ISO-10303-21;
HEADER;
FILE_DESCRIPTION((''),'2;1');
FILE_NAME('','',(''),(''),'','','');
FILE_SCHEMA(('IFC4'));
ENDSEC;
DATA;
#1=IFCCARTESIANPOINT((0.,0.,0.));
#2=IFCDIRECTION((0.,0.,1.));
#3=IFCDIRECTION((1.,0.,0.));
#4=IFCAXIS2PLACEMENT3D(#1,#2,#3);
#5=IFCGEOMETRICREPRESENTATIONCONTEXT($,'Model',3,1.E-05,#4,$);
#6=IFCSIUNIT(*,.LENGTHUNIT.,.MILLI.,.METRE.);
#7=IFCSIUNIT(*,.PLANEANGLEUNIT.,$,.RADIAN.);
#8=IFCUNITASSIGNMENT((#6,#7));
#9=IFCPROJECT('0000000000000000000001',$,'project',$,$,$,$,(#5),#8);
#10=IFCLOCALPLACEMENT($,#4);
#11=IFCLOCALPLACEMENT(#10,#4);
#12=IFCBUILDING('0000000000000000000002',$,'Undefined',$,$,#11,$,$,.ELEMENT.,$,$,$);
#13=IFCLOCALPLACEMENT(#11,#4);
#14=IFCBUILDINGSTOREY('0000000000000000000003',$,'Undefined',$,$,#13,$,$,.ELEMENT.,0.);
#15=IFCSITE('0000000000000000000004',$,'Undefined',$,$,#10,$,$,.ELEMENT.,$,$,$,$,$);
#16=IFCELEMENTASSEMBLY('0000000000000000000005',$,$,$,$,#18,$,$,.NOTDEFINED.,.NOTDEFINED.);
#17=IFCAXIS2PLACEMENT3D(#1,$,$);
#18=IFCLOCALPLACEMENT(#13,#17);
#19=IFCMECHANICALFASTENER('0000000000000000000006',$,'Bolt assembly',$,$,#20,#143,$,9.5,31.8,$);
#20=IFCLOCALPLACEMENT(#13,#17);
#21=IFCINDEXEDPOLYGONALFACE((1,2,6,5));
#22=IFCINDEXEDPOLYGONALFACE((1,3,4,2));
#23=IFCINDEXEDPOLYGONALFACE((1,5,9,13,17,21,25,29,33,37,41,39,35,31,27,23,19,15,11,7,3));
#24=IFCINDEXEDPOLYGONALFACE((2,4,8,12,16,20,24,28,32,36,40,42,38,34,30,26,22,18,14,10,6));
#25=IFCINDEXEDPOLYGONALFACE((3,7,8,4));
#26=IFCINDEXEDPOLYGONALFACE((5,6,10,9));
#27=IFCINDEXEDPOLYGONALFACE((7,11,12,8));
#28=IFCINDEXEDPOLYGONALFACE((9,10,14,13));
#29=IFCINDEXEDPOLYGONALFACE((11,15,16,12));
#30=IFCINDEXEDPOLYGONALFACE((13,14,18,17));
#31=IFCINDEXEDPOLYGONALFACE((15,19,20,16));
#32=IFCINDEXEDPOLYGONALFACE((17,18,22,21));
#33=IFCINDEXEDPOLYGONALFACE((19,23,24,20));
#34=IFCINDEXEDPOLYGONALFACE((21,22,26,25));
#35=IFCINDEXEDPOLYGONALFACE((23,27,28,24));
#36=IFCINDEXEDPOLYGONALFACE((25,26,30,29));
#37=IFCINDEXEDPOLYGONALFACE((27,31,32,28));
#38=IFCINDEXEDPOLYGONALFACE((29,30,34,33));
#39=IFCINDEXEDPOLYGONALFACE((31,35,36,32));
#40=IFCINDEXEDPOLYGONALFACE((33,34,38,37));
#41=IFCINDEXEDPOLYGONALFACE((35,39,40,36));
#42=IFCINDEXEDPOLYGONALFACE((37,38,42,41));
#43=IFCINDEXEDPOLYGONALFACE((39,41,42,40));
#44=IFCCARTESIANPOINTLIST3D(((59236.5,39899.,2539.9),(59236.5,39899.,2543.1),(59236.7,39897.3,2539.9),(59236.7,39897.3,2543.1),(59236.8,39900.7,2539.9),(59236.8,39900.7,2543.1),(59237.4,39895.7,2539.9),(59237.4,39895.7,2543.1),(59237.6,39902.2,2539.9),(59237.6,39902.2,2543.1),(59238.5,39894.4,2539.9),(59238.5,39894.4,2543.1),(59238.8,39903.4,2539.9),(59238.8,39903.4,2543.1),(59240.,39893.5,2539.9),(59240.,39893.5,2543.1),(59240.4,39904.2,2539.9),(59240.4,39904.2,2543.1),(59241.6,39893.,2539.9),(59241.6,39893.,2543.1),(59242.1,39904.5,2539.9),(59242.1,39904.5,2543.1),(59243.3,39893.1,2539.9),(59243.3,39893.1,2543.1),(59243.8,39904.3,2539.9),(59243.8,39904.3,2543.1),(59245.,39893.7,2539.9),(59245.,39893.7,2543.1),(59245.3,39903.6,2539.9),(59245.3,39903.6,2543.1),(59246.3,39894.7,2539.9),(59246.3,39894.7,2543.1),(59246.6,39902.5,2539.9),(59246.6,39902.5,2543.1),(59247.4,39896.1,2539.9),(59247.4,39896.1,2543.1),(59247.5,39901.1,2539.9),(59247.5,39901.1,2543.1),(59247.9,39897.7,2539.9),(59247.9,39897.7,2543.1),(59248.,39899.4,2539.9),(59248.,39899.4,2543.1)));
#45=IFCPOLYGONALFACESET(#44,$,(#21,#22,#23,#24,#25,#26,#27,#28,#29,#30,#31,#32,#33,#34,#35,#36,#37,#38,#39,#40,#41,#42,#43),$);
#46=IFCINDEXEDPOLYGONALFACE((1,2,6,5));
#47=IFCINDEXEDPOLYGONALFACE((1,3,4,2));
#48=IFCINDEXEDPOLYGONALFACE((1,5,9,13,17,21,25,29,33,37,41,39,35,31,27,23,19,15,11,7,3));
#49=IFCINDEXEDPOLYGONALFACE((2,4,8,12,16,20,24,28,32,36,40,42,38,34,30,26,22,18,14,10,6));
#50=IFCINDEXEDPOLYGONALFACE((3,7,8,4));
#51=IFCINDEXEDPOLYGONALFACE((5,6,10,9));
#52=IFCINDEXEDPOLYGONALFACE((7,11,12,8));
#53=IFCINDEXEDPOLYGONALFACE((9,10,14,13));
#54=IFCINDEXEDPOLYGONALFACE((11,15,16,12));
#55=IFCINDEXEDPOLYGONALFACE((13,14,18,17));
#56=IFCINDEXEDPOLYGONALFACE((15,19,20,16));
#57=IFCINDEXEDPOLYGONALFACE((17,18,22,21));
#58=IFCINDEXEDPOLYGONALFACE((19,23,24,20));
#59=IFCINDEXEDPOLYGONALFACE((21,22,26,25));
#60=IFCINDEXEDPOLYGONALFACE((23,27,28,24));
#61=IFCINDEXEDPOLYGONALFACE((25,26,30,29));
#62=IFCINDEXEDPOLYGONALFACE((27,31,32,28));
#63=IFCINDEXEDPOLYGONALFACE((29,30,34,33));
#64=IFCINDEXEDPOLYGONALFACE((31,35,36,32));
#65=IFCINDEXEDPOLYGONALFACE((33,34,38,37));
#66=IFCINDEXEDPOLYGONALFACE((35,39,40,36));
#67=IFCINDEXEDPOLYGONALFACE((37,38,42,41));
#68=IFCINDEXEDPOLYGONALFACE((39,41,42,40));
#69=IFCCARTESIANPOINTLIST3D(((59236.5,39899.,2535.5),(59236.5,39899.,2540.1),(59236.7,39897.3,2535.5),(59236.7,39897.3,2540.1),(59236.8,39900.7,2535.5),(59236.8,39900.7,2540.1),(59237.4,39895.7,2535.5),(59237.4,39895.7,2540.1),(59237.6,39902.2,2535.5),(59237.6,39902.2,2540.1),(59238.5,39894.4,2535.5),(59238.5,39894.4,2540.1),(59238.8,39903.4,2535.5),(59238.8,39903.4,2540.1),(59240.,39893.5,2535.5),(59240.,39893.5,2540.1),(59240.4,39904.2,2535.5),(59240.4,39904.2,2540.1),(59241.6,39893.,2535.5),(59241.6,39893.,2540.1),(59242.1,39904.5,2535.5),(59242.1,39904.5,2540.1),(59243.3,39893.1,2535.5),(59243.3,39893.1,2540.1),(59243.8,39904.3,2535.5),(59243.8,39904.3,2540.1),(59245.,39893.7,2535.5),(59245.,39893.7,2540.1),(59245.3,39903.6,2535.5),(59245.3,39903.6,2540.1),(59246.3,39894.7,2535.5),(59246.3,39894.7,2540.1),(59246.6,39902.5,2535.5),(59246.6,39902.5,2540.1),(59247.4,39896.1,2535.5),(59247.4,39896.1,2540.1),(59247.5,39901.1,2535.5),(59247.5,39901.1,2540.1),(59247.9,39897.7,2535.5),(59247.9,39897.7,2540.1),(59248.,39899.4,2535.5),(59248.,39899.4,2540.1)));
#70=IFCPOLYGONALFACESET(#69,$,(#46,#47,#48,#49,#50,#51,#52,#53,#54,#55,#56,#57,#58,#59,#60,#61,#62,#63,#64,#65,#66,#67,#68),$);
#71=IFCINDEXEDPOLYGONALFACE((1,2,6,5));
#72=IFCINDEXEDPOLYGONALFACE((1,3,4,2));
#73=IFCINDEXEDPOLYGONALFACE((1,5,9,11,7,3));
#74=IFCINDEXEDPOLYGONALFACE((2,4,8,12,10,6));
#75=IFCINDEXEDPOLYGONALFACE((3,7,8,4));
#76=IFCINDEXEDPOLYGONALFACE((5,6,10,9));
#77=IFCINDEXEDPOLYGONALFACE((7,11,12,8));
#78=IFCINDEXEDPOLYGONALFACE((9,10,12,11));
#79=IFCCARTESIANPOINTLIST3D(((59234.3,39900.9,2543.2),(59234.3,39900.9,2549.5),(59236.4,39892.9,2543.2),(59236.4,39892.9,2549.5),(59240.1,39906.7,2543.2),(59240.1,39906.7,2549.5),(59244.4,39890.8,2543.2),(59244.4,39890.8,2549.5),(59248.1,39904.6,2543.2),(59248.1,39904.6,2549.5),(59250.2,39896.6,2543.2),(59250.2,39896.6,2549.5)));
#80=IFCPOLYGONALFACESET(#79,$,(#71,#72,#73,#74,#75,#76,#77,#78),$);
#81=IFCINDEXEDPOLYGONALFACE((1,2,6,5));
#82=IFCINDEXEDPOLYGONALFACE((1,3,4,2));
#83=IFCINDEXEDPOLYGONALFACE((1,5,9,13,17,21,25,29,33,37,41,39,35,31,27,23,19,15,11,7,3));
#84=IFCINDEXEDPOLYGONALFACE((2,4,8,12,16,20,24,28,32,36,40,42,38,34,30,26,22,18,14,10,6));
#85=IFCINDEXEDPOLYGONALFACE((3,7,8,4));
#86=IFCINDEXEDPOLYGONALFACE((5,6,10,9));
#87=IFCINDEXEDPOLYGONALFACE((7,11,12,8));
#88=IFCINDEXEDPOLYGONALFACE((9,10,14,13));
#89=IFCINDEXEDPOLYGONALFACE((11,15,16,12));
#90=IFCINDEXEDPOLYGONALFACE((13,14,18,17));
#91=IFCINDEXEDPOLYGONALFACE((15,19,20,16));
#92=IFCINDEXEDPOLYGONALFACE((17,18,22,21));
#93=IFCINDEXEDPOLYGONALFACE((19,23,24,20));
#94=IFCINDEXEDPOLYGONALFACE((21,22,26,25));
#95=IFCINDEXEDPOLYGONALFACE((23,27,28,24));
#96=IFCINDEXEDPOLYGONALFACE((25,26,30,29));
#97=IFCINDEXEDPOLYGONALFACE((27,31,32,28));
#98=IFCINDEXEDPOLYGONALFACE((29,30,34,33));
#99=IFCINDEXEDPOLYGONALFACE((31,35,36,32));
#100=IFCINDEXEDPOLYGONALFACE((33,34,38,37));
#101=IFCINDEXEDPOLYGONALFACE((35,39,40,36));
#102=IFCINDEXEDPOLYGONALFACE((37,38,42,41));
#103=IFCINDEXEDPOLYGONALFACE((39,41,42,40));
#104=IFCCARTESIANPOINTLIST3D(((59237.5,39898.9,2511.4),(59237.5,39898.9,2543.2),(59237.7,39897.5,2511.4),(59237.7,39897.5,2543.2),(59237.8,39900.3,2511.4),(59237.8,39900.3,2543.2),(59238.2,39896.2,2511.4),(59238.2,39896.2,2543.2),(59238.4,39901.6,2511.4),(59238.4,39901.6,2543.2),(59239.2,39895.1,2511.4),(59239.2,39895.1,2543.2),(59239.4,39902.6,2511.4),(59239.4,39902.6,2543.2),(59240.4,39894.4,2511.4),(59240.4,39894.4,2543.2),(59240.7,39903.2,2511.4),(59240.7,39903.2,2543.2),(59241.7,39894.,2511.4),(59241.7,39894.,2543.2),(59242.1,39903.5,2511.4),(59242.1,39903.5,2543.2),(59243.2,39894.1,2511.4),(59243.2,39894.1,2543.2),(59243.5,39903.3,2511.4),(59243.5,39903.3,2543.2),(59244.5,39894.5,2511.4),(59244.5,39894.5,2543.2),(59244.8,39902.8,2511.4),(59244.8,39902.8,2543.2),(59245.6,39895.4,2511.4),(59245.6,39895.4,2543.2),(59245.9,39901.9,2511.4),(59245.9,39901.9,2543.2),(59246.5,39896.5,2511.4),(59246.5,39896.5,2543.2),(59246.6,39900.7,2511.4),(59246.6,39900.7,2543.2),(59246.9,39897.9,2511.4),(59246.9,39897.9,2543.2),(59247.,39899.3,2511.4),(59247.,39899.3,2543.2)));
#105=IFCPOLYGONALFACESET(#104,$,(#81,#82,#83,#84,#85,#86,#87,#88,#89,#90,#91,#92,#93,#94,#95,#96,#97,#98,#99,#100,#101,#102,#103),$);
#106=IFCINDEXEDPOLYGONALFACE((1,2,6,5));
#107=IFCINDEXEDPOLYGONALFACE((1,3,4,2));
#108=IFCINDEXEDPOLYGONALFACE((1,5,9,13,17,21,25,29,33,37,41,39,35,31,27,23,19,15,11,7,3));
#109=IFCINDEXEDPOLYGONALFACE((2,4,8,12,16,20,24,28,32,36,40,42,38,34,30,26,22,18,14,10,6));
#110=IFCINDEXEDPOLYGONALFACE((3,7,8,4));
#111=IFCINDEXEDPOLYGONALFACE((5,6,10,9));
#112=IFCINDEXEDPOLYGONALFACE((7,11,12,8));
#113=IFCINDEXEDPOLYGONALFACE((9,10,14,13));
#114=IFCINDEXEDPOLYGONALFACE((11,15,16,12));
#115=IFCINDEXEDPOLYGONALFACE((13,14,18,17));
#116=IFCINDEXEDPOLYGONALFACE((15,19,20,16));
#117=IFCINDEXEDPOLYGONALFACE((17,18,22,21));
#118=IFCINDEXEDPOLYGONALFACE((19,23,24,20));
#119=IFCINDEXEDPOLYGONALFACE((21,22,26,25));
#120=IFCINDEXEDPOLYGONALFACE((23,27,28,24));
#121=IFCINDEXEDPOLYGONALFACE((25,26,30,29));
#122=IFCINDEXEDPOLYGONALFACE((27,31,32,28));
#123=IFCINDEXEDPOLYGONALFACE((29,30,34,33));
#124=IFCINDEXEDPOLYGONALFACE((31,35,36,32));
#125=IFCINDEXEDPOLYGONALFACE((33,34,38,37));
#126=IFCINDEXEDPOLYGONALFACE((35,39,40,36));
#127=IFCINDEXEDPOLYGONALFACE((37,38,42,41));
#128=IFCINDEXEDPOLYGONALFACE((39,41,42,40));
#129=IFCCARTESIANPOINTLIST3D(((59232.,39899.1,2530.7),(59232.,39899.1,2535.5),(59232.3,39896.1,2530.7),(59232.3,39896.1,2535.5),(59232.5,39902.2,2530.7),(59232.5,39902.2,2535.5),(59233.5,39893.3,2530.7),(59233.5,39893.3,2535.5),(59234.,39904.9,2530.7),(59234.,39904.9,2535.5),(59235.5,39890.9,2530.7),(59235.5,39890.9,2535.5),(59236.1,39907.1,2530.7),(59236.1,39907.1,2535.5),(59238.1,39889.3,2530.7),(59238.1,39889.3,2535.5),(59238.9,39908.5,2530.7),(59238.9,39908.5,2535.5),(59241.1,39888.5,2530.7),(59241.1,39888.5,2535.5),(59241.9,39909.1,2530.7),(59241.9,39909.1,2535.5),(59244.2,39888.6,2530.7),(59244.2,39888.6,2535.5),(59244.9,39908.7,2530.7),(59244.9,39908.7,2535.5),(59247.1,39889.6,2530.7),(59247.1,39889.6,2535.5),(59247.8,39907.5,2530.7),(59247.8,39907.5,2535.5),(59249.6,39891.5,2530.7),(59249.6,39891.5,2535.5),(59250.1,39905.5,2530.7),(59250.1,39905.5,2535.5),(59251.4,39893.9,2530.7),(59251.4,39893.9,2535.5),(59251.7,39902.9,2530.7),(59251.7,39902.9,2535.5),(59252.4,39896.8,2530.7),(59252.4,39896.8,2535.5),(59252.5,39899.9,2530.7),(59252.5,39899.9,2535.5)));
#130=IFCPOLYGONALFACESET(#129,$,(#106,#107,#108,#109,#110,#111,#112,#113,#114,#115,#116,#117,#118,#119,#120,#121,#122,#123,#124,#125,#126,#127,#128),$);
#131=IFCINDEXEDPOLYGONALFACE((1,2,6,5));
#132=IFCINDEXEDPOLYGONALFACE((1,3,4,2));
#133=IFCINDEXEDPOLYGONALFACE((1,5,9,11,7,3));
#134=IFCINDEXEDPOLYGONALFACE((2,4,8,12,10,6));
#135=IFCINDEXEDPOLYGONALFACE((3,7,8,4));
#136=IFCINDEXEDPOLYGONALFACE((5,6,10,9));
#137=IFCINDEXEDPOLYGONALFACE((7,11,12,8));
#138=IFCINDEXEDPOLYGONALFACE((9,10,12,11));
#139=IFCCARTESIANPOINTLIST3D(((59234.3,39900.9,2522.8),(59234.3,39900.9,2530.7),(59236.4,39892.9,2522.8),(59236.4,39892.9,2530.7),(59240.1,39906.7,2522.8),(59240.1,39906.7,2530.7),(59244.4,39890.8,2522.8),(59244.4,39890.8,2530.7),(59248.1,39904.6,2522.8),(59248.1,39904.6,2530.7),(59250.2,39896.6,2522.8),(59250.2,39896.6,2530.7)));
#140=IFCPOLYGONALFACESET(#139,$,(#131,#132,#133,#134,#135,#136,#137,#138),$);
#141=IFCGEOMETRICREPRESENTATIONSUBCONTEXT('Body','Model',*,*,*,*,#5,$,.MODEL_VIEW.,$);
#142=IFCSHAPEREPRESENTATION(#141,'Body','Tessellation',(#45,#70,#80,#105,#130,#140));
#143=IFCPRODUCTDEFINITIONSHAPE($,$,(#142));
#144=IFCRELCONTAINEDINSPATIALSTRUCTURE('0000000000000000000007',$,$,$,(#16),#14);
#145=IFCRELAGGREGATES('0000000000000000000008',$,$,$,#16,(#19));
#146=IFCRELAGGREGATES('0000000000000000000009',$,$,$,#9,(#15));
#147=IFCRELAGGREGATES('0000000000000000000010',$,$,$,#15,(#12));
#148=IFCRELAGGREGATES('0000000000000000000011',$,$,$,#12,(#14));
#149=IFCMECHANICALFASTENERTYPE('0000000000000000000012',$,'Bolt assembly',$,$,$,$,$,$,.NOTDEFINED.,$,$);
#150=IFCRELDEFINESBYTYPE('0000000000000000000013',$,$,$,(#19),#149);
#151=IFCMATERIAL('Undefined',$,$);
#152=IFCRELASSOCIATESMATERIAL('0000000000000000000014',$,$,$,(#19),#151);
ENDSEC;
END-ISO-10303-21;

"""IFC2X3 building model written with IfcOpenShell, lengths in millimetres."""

from ifc_helpers import new_model, si_unit, frame, origin_with_axes, origin_2d_with_axis, place, context, subcontext, project, spatial, polyline, circle, outline, extrude, source, transform, mapped, material, type_object, element, aggregate, save


model = new_model("IFC2X3")

# Units and contexts
model_context = context("Model", 3, precision=1e-05, world=origin_with_axes())
body_context = subcontext(model_context, "Body", "Model", "MODEL_VIEW")
ifc_project = project(units=[si_unit("LENGTHUNIT", "METRE", prefix="MILLI"), si_unit("PLANEANGLEUNIT", "RADIAN")], contexts=[model_context])

# Site, building, storey
site_placement = place(None, origin_with_axes())
site = spatial("IfcSite", under=ifc_project, at=site_placement, Name="Undefined", CompositionType="ELEMENT")
building_placement = place(site_placement, origin_with_axes())
building = spatial("IfcBuilding", under=site, at=building_placement, Name="Undefined", CompositionType="ELEMENT")
storey_placement = place(building_placement, origin_with_axes())
storey = spatial("IfcBuildingStorey", under=building, at=storey_placement, Name="Undefined", CompositionType="ELEMENT", Elevation=0.0)

# Element assembly
assembly_1_placement = place(storey_placement, origin_with_axes())
assembly_1 = element("IfcElementAssembly", 1, at=assembly_1_placement, inside=storey, AssemblyPlace="NOTDEFINED", PredefinedType="NOTDEFINED")

# Shared definitions
ifc_material_1 = material(Name="Undefined")
mechanical_fastener_type = type_object("IfcMechanicalFastenerType", Name="Bolt assembly")

# Mechanical fastener
shared_shape_1 = source(origin_with_axes(), body_context, "Body", "SweptSolid", [
    extrude(circle(Radius=5.8, at=origin_2d_with_axis()), frame((0.0, -7.6, 0.0), z_axis=(0.0, 1.0, 0.0), x_axis=(1.0, 0.0, 0.0)), (0.0, 0.0, 1.0), 3.2),
    extrude(circle(Radius=5.8, at=origin_2d_with_axis()), frame((0.0, -4.6, 0.0), z_axis=(0.0, 1.0, 0.0), x_axis=(1.0, 0.0, 0.0)), (0.0, 0.0, 1.0), 4.6),
    extrude(outline(polyline([(7.1, -4.1), (7.1, 4.1), (0.0, 8.2), (-7.1, 4.1), (-7.1, -4.1), (0.0, -8.2), (7.1, -4.1)])), frame((0.0, -14.0, 0.0), z_axis=(0.0, 1.0, 0.0), x_axis=(1.0, 0.0, 0.0)), (0.0, 0.0, 1.0), 6.3),
    extrude(circle(Radius=4.8, at=origin_2d_with_axis()), frame((0.0, -7.7, 0.0), z_axis=(0.0, 1.0, 0.0), x_axis=(1.0, 0.0, 0.0)), (0.0, 0.0, 1.0), 31.8),
    extrude(circle(Radius=10.3, at=origin_2d_with_axis()), frame((0.0, 0.0, 0.0), z_axis=(0.0, 1.0, 0.0), x_axis=(1.0, 0.0, 0.0)), (0.0, 0.0, 1.0), 4.8),
    extrude(outline(polyline([(7.1, -4.1), (7.1, 4.1), (0.0, 8.2), (-7.1, 4.1), (-7.1, -4.1), (0.0, -8.2), (7.1, -4.1)])), frame((0.0, 4.8, 0.0), z_axis=(0.0, 1.0, 0.0), x_axis=(1.0, 0.0, 0.0)), (0.0, 0.0, 1.0), 7.9),
])
mechanical_fastener_1_placement = place(assembly_1_placement, frame((59242.3, 39898.7, 2535.5), z_axis=(0.707107, 0.707107, 0.0), x_axis=(0.707107, -0.707107, 0.0)))
mechanical_fastener_1 = element("IfcMechanicalFastener", 2, at=mechanical_fastener_1_placement, type_object=mechanical_fastener_type, material=ifc_material_1, Name="Bolt assembly", NominalDiameter=9.5, NominalLength=31.8, context=body_context, shape_type="MappedRepresentation", body=[
    mapped(shared_shape_1, transform((0.0, 0.0, 0.0))),
])
aggregate(assembly_1, [mechanical_fastener_1])

save(model, "model.ifc")
